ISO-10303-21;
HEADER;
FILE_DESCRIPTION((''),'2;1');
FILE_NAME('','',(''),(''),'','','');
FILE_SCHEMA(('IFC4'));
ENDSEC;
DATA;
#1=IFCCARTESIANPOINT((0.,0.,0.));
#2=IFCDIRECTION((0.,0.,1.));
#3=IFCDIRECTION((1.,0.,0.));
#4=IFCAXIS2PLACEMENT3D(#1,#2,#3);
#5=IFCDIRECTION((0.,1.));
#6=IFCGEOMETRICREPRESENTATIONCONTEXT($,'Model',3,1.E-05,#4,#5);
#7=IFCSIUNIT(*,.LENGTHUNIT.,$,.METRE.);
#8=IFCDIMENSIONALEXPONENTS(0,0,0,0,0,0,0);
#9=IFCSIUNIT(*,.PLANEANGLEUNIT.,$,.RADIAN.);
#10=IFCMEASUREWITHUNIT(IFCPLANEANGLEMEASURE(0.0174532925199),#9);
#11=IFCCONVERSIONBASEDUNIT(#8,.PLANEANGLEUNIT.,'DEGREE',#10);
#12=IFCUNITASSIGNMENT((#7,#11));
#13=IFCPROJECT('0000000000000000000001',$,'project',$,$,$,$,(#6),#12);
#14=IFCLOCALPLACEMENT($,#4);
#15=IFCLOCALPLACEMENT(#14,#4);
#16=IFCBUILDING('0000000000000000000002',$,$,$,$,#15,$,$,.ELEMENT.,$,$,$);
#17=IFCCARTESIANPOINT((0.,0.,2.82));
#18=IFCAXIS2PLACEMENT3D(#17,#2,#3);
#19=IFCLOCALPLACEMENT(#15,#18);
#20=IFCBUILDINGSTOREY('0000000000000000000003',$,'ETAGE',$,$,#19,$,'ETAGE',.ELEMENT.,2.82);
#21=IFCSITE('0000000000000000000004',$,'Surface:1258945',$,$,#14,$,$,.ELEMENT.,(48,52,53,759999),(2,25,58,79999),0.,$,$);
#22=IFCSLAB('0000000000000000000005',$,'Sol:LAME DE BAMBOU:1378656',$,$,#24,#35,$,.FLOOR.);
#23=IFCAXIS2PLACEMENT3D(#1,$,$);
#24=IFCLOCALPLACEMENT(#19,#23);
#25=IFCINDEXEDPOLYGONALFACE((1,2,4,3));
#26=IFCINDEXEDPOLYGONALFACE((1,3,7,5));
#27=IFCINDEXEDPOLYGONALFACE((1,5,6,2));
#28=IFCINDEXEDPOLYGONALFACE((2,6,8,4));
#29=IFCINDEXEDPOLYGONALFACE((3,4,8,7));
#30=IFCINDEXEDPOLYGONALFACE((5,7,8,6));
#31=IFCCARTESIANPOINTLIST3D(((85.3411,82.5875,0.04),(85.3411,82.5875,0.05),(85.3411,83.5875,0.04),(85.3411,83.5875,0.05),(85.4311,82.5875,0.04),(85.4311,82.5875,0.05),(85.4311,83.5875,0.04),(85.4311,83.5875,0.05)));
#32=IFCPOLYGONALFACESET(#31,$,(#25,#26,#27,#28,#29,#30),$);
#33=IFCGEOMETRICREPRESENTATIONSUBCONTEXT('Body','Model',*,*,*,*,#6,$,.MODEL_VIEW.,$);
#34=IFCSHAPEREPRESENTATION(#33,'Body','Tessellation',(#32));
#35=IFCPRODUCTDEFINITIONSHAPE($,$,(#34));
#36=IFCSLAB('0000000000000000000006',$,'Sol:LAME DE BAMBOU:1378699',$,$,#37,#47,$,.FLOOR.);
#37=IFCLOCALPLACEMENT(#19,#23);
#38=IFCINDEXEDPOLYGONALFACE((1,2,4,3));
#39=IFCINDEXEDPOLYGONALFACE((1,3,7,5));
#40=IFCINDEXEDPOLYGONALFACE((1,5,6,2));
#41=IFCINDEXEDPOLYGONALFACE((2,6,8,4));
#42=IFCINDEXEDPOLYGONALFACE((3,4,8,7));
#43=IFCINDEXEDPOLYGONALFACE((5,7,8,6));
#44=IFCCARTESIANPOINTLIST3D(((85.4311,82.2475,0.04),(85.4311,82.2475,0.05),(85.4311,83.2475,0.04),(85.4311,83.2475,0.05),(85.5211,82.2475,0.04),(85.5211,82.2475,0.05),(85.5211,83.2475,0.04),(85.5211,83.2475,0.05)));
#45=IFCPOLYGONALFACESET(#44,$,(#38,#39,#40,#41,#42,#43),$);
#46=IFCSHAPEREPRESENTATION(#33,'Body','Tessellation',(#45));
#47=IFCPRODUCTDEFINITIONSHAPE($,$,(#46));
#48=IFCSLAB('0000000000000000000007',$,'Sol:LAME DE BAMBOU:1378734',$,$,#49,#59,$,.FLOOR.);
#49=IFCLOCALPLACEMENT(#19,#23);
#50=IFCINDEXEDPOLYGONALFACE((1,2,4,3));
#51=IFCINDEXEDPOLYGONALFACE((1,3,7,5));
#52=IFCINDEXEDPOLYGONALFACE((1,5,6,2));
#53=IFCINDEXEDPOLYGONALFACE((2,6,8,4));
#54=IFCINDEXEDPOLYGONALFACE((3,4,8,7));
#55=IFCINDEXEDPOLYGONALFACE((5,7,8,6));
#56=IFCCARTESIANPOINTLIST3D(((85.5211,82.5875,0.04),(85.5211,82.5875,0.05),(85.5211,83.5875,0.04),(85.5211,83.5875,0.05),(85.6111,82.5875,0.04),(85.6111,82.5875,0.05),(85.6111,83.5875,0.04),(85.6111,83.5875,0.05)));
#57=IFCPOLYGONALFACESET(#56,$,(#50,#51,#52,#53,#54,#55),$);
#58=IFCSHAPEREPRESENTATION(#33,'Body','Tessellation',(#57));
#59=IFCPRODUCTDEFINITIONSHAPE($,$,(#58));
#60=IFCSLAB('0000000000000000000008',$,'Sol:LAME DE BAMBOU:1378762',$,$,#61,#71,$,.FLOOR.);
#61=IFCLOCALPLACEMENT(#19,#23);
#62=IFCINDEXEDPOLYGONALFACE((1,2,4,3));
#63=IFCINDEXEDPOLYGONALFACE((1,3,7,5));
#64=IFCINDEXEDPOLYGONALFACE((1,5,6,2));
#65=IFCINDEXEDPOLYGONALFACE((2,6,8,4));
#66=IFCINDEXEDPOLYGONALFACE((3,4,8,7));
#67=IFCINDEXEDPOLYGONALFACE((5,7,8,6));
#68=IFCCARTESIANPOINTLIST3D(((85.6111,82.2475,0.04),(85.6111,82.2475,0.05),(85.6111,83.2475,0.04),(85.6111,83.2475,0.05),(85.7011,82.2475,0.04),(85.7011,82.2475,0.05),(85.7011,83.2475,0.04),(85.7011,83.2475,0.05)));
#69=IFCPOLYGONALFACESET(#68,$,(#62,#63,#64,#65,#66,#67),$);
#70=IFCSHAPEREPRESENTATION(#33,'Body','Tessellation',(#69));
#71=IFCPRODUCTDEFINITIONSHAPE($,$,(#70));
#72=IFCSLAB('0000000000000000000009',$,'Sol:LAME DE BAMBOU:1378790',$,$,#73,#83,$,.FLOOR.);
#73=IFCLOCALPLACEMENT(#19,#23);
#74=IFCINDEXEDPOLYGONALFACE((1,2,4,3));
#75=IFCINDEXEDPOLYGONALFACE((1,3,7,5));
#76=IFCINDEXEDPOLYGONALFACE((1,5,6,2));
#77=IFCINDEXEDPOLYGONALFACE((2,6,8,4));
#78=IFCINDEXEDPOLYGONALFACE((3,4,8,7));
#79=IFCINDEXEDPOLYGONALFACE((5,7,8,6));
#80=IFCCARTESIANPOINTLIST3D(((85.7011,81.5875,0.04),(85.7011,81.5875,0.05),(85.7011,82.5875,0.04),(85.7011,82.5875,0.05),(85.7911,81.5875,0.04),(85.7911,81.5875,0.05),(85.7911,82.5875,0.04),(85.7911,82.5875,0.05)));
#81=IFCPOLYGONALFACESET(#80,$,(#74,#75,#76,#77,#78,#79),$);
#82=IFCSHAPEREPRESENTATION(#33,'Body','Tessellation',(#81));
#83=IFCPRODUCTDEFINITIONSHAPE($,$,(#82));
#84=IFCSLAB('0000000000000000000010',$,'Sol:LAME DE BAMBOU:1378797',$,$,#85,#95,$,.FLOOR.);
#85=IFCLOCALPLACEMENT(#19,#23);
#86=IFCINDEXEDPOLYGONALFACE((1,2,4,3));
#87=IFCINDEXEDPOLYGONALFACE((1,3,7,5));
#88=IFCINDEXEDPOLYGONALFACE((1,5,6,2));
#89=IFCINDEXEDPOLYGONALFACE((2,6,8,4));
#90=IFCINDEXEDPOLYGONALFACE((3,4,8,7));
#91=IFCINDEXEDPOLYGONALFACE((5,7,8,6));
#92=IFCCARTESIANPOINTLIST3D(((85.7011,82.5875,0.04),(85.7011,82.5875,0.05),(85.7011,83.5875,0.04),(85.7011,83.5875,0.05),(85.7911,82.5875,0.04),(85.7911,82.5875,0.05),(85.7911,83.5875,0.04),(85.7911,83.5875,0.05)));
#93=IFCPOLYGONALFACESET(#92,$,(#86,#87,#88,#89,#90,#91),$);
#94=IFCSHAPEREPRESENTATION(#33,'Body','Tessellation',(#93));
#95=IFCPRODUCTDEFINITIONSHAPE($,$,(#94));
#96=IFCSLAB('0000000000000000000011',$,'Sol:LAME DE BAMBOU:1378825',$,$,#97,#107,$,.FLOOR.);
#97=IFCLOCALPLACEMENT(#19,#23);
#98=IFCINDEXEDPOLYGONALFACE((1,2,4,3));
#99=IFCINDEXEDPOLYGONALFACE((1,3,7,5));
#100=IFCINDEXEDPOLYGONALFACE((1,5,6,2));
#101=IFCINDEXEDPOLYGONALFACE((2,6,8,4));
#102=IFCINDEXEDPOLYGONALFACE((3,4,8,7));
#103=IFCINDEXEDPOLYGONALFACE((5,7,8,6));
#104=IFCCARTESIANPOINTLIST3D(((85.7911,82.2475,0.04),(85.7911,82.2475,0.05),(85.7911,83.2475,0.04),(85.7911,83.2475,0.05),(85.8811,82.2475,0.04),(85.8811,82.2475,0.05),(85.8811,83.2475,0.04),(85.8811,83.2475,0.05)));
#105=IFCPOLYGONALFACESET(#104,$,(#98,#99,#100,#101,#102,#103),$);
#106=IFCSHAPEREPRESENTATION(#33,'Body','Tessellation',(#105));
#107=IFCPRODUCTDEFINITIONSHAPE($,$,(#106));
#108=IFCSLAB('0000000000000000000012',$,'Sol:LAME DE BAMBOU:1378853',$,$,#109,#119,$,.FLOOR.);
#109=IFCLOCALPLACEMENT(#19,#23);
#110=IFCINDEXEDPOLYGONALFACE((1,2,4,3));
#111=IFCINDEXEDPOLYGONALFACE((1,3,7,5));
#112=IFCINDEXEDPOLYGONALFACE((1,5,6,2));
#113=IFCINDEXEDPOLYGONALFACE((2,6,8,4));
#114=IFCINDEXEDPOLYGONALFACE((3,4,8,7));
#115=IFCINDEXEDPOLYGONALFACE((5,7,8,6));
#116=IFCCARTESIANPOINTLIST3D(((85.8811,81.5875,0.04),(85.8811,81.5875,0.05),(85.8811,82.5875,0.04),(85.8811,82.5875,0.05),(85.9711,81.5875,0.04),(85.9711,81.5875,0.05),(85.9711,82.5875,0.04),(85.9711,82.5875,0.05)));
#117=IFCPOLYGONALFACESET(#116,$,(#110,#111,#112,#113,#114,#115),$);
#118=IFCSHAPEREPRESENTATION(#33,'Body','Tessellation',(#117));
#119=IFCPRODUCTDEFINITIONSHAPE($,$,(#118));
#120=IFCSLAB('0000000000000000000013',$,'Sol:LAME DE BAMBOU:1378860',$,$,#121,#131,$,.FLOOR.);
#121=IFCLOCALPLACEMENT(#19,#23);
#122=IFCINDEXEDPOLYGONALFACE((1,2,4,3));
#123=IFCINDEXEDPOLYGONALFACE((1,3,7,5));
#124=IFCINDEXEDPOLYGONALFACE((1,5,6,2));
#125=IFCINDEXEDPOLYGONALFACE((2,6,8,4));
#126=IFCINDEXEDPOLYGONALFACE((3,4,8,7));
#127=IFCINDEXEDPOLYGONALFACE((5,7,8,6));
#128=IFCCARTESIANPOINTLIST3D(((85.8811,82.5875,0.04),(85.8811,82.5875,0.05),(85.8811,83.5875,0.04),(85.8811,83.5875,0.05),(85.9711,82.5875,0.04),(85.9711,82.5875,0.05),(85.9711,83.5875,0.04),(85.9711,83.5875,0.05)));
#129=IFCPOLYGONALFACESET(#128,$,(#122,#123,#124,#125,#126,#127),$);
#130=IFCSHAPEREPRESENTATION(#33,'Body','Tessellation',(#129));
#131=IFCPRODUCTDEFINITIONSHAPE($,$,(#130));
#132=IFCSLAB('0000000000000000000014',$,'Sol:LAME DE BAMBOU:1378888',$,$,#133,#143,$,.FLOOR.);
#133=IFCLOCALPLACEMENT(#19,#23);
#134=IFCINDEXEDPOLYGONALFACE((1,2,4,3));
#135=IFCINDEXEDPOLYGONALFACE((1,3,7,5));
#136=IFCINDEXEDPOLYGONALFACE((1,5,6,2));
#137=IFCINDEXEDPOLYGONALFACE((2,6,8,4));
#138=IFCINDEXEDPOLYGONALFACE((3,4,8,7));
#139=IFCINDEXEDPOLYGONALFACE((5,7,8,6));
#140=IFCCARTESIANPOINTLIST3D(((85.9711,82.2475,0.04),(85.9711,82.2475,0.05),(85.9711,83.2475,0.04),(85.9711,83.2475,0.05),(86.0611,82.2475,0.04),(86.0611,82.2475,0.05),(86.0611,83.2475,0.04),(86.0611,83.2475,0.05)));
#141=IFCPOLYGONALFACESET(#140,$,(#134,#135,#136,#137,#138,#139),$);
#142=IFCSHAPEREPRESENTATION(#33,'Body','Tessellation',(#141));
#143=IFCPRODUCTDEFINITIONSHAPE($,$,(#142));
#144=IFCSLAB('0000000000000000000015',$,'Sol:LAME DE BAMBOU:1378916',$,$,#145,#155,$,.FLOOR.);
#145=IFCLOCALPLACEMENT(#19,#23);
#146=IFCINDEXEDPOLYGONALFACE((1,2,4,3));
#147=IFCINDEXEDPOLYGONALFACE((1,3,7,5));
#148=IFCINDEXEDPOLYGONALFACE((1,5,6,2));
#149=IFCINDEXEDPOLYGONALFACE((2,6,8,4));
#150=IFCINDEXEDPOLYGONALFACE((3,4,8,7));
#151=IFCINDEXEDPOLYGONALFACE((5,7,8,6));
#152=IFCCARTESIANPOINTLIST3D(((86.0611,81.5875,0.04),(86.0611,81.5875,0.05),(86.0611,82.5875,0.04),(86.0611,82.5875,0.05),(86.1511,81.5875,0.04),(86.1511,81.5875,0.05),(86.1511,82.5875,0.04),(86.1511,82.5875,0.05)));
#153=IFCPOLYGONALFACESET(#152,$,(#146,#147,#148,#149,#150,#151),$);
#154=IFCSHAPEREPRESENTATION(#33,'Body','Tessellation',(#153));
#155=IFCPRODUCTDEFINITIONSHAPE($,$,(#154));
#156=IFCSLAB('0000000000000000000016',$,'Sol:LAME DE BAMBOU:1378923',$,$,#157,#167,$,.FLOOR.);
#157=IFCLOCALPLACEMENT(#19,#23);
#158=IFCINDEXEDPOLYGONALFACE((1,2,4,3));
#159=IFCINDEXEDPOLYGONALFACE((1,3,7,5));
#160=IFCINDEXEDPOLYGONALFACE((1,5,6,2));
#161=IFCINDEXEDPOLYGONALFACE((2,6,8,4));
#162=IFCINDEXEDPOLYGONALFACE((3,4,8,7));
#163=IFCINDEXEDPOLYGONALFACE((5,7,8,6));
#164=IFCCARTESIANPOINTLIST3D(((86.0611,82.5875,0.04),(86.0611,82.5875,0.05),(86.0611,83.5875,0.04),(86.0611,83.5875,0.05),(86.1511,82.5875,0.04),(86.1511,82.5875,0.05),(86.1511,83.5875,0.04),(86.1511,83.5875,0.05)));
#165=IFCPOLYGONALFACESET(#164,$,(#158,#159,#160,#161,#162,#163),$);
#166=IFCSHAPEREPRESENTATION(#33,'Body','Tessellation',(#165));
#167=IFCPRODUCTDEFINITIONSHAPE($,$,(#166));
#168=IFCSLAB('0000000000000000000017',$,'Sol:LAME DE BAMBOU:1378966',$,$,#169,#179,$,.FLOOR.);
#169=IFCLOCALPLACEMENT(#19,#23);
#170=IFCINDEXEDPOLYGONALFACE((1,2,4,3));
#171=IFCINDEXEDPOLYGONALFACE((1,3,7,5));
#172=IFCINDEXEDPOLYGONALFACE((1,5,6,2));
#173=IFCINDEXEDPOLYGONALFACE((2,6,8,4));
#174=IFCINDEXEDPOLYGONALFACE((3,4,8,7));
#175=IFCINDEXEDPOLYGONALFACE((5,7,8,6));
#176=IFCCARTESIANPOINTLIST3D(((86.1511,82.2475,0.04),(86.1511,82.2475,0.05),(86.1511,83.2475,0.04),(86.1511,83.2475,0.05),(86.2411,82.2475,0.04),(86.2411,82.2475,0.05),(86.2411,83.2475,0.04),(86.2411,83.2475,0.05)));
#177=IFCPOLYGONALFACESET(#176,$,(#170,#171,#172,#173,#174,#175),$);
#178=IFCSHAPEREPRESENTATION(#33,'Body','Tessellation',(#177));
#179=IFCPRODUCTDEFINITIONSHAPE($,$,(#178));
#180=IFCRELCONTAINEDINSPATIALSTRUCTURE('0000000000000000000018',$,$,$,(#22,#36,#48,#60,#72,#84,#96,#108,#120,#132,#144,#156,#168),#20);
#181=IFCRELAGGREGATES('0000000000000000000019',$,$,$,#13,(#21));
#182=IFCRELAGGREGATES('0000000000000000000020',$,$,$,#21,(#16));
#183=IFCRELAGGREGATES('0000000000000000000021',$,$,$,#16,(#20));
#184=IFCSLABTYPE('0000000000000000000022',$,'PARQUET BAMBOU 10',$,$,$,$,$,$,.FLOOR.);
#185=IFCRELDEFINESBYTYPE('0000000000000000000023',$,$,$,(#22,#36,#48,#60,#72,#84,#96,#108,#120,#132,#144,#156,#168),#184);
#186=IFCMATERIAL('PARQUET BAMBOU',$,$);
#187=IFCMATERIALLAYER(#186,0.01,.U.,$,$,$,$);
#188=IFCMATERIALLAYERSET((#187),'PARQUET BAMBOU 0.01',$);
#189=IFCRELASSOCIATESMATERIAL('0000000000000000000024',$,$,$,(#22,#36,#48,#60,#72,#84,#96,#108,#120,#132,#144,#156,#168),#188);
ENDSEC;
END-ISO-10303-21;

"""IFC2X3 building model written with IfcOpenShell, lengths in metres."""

from ifc_helpers import new_model, entity, si_unit, converted_unit, direction, frame, origin_with_axes, place, context, subcontext, project, spatial, polyline, outline, extrude, material, layer, layer_set, layer_usage, type_object, element, save


model = new_model("IFC2X3")

# Units and contexts
model_context = context("Model", 3, precision=1e-05, world=origin_with_axes(), true_north=direction((0.0, 1.0)))
body_context = subcontext(model_context, "Body", "Model", "MODEL_VIEW")
ifc_project = project(units=[si_unit("LENGTHUNIT", "METRE"), converted_unit("PLANEANGLEUNIT", "DEGREE", entity("IfcPlaneAngleMeasure", 0.0174532925199), si_unit("PLANEANGLEUNIT", "RADIAN"), dimensions=[0, 0, 0, 0, 0, 0, 0])], contexts=[model_context])

# Site, building, storey
site_placement = place(None, origin_with_axes())
site = spatial("IfcSite", under=ifc_project, at=site_placement, Name="Surface:1258945", CompositionType="ELEMENT", RefLatitude=(48, 52, 53, 759999), RefLongitude=(2, 25, 58, 79999), RefElevation=0.0)
building_placement = place(site_placement, origin_with_axes())
building = spatial("IfcBuilding", under=site, at=building_placement, CompositionType="ELEMENT")
storey_placement = place(building_placement, frame((0.0, 0.0, 2.82), z_axis=(0.0, 0.0, 1.0), x_axis=(1.0, 0.0, 0.0)))
storey = spatial("IfcBuildingStorey", under=building, at=storey_placement, Name="ETAGE", LongName="ETAGE", CompositionType="ELEMENT", Elevation=2.82)

# Slabs
ifc_material = material(Name="PARQUET BAMBOU")
ifc_layer = layer(ifc_material, 0.01, ventilated="UNKNOWN")
ifc_layer_set = layer_set([ifc_layer], Name="PARQUET BAMBOU 0.01")
ifc_layer_usage_1 = layer_usage(ifc_layer_set, "AXIS3", "NEGATIVE", 0.01)
slab_type = type_object("IfcSlabType", Name="PARQUET BAMBOU 10", PredefinedType="FLOOR")
slab_1_placement = place(storey_placement, frame((85.3411, 83.5875, 0.05), z_axis=(0.0, 0.0, 1.0), x_axis=(1.0, 0.0, 0.0)))
element("IfcSlab", 1, at=slab_1_placement, inside=storey, type_object=slab_type, material=ifc_layer_usage_1, Name="Sol:LAME DE BAMBOU:1378656", PredefinedType="FLOOR", context=body_context, shape_type="SweptSolid", body=[
    extrude(outline(polyline([(0.0, 0.0), (0.0, -1.0), (0.09, -1.0), (0.09, 0.0), (0.0, 0.0)])), frame((0.0, 0.0, -0.01), z_axis=(0.0, 0.0, 1.0), x_axis=(1.0, 0.0, 0.0)), (0.0, 0.0, 1.0), 0.01),
])
ifc_layer_usage_2 = layer_usage(ifc_layer_set, "AXIS3", "NEGATIVE", 0.01)
slab_2_placement = place(storey_placement, frame((85.4311, 83.2475, 0.05), z_axis=(0.0, 0.0, 1.0), x_axis=(1.0, 0.0, 0.0)))
element("IfcSlab", 2, at=slab_2_placement, inside=storey, type_object=slab_type, material=ifc_layer_usage_2, Name="Sol:LAME DE BAMBOU:1378699", PredefinedType="FLOOR", context=body_context, shape_type="SweptSolid", body=[
    extrude(outline(polyline([(0.0, 0.0), (0.0, -1.0), (0.09, -1.0), (0.09, 0.0), (0.0, 0.0)])), frame((0.0, 0.0, -0.01), z_axis=(0.0, 0.0, 1.0), x_axis=(1.0, 0.0, 0.0)), (0.0, 0.0, 1.0), 0.01),
])
ifc_layer_usage_3 = layer_usage(ifc_layer_set, "AXIS3", "NEGATIVE", 0.01)
slab_3_placement = place(storey_placement, frame((85.5211, 83.5875, 0.05), z_axis=(0.0, 0.0, 1.0), x_axis=(1.0, 0.0, 0.0)))
element("IfcSlab", 3, at=slab_3_placement, inside=storey, type_object=slab_type, material=ifc_layer_usage_3, Name="Sol:LAME DE BAMBOU:1378734", PredefinedType="FLOOR", context=body_context, shape_type="SweptSolid", body=[
    extrude(outline(polyline([(0.0, 0.0), (0.0, -1.0), (0.09, -1.0), (0.09, 0.0), (0.0, 0.0)])), frame((0.0, 0.0, -0.01), z_axis=(0.0, 0.0, 1.0), x_axis=(1.0, 0.0, 0.0)), (0.0, 0.0, 1.0), 0.01),
])
ifc_layer_usage_4 = layer_usage(ifc_layer_set, "AXIS3", "NEGATIVE", 0.01)
slab_4_placement = place(storey_placement, frame((85.6111, 83.2475, 0.05), z_axis=(0.0, 0.0, 1.0), x_axis=(1.0, 0.0, 0.0)))
element("IfcSlab", 4, at=slab_4_placement, inside=storey, type_object=slab_type, material=ifc_layer_usage_4, Name="Sol:LAME DE BAMBOU:1378762", PredefinedType="FLOOR", context=body_context, shape_type="SweptSolid", body=[
    extrude(outline(polyline([(0.0, 0.0), (0.0, -1.0), (0.09, -1.0), (0.09, 0.0), (0.0, 0.0)])), frame((0.0, 0.0, -0.01), z_axis=(0.0, 0.0, 1.0), x_axis=(1.0, 0.0, 0.0)), (0.0, 0.0, 1.0), 0.01),
])
ifc_layer_usage_5 = layer_usage(ifc_layer_set, "AXIS3", "NEGATIVE", 0.01)
slab_5_placement = place(storey_placement, frame((85.7011, 82.5875, 0.05), z_axis=(0.0, 0.0, 1.0), x_axis=(1.0, 0.0, 0.0)))
element("IfcSlab", 5, at=slab_5_placement, inside=storey, type_object=slab_type, material=ifc_layer_usage_5, Name="Sol:LAME DE BAMBOU:1378790", PredefinedType="FLOOR", context=body_context, shape_type="SweptSolid", body=[
    extrude(outline(polyline([(0.0, 0.0), (0.0, -1.0), (0.09, -1.0), (0.09, 0.0), (0.0, 0.0)])), frame((0.0, 0.0, -0.01), z_axis=(0.0, 0.0, 1.0), x_axis=(1.0, 0.0, 0.0)), (0.0, 0.0, 1.0), 0.01),
])
ifc_layer_usage_6 = layer_usage(ifc_layer_set, "AXIS3", "NEGATIVE", 0.01)
slab_6_placement = place(storey_placement, frame((85.7011, 83.5875, 0.05), z_axis=(0.0, 0.0, 1.0), x_axis=(1.0, 0.0, 0.0)))
element("IfcSlab", 6, at=slab_6_placement, inside=storey, type_object=slab_type, material=ifc_layer_usage_6, Name="Sol:LAME DE BAMBOU:1378797", PredefinedType="FLOOR", context=body_context, shape_type="SweptSolid", body=[
    extrude(outline(polyline([(0.0, 0.0), (0.0, -1.0), (0.09, -1.0), (0.09, 0.0), (0.0, 0.0)])), frame((0.0, 0.0, -0.01), z_axis=(0.0, 0.0, 1.0), x_axis=(1.0, 0.0, 0.0)), (0.0, 0.0, 1.0), 0.01),
])
ifc_layer_usage_7 = layer_usage(ifc_layer_set, "AXIS3", "NEGATIVE", 0.01)
slab_7_placement = place(storey_placement, frame((85.7911, 83.2475, 0.05), z_axis=(0.0, 0.0, 1.0), x_axis=(1.0, 0.0, 0.0)))
element("IfcSlab", 7, at=slab_7_placement, inside=storey, type_object=slab_type, material=ifc_layer_usage_7, Name="Sol:LAME DE BAMBOU:1378825", PredefinedType="FLOOR", context=body_context, shape_type="SweptSolid", body=[
    extrude(outline(polyline([(0.0, 0.0), (0.0, -1.0), (0.09, -1.0), (0.09, 0.0), (0.0, 0.0)])), frame((0.0, 0.0, -0.01), z_axis=(0.0, 0.0, 1.0), x_axis=(1.0, 0.0, 0.0)), (0.0, 0.0, 1.0), 0.01),
])
ifc_layer_usage_8 = layer_usage(ifc_layer_set, "AXIS3", "NEGATIVE", 0.01)
slab_8_placement = place(storey_placement, frame((85.8811, 82.5875, 0.05), z_axis=(0.0, 0.0, 1.0), x_axis=(1.0, 0.0, 0.0)))
element("IfcSlab", 8, at=slab_8_placement, inside=storey, type_object=slab_type, material=ifc_layer_usage_8, Name="Sol:LAME DE BAMBOU:1378853", PredefinedType="FLOOR", context=body_context, shape_type="SweptSolid", body=[
    extrude(outline(polyline([(0.0, 0.0), (0.0, -1.0), (0.09, -1.0), (0.09, 0.0), (0.0, 0.0)])), frame((0.0, 0.0, -0.01), z_axis=(0.0, 0.0, 1.0), x_axis=(1.0, 0.0, 0.0)), (0.0, 0.0, 1.0), 0.01),
])
ifc_layer_usage_9 = layer_usage(ifc_layer_set, "AXIS3", "NEGATIVE", 0.01)
slab_9_placement = place(storey_placement, frame((85.8811, 83.5875, 0.05), z_axis=(0.0, 0.0, 1.0), x_axis=(1.0, 0.0, 0.0)))
element("IfcSlab", 9, at=slab_9_placement, inside=storey, type_object=slab_type, material=ifc_layer_usage_9, Name="Sol:LAME DE BAMBOU:1378860", PredefinedType="FLOOR", context=body_context, shape_type="SweptSolid", body=[
    extrude(outline(polyline([(0.0, 0.0), (0.0, -1.0), (0.09, -1.0), (0.09, 0.0), (0.0, 0.0)])), frame((0.0, 0.0, -0.01), z_axis=(0.0, 0.0, 1.0), x_axis=(1.0, 0.0, 0.0)), (0.0, 0.0, 1.0), 0.01),
])
ifc_layer_usage_10 = layer_usage(ifc_layer_set, "AXIS3", "NEGATIVE", 0.01)
slab_10_placement = place(storey_placement, frame((85.9711, 83.2475, 0.05), z_axis=(0.0, 0.0, 1.0), x_axis=(1.0, 0.0, 0.0)))
element("IfcSlab", 10, at=slab_10_placement, inside=storey, type_object=slab_type, material=ifc_layer_usage_10, Name="Sol:LAME DE BAMBOU:1378888", PredefinedType="FLOOR", context=body_context, shape_type="SweptSolid", body=[
    extrude(outline(polyline([(0.0, 0.0), (0.0, -1.0), (0.09, -1.0), (0.09, 0.0), (0.0, 0.0)])), frame((0.0, 0.0, -0.01), z_axis=(0.0, 0.0, 1.0), x_axis=(1.0, 0.0, 0.0)), (0.0, 0.0, 1.0), 0.01),
])
ifc_layer_usage_11 = layer_usage(ifc_layer_set, "AXIS3", "NEGATIVE", 0.01)
slab_11_placement = place(storey_placement, frame((86.0611, 82.5875, 0.05), z_axis=(0.0, 0.0, 1.0), x_axis=(1.0, 0.0, 0.0)))
element("IfcSlab", 11, at=slab_11_placement, inside=storey, type_object=slab_type, material=ifc_layer_usage_11, Name="Sol:LAME DE BAMBOU:1378916", PredefinedType="FLOOR", context=body_context, shape_type="SweptSolid", body=[
    extrude(outline(polyline([(0.0, 0.0), (0.0, -1.0), (0.09, -1.0), (0.09, 0.0), (0.0, 0.0)])), frame((0.0, 0.0, -0.01), z_axis=(0.0, 0.0, 1.0), x_axis=(1.0, 0.0, 0.0)), (0.0, 0.0, 1.0), 0.01),
])
ifc_layer_usage_12 = layer_usage(ifc_layer_set, "AXIS3", "NEGATIVE", 0.01)
slab_12_placement = place(storey_placement, frame((86.0611, 83.5875, 0.05), z_axis=(0.0, 0.0, 1.0), x_axis=(1.0, 0.0, 0.0)))
element("IfcSlab", 12, at=slab_12_placement, inside=storey, type_object=slab_type, material=ifc_layer_usage_12, Name="Sol:LAME DE BAMBOU:1378923", PredefinedType="FLOOR", context=body_context, shape_type="SweptSolid", body=[
    extrude(outline(polyline([(0.0, 0.0), (0.0, -1.0), (0.09, -1.0), (0.09, 0.0), (0.0, 0.0)])), frame((0.0, 0.0, -0.01), z_axis=(0.0, 0.0, 1.0), x_axis=(1.0, 0.0, 0.0)), (0.0, 0.0, 1.0), 0.01),
])
ifc_layer_usage_13 = layer_usage(ifc_layer_set, "AXIS3", "NEGATIVE", 0.01)
slab_13_placement = place(storey_placement, frame((86.1511, 83.2475, 0.05), z_axis=(0.0, 0.0, 1.0), x_axis=(1.0, 0.0, 0.0)))
element("IfcSlab", 13, at=slab_13_placement, inside=storey, type_object=slab_type, material=ifc_layer_usage_13, Name="Sol:LAME DE BAMBOU:1378966", PredefinedType="FLOOR", context=body_context, shape_type="SweptSolid", body=[
    extrude(outline(polyline([(0.0, 0.0), (0.0, -1.0), (0.09, -1.0), (0.09, 0.0), (0.0, 0.0)])), frame((0.0, 0.0, -0.01), z_axis=(0.0, 0.0, 1.0), x_axis=(1.0, 0.0, 0.0)), (0.0, 0.0, 1.0), 0.01),
])

save(model, "model.ifc")
